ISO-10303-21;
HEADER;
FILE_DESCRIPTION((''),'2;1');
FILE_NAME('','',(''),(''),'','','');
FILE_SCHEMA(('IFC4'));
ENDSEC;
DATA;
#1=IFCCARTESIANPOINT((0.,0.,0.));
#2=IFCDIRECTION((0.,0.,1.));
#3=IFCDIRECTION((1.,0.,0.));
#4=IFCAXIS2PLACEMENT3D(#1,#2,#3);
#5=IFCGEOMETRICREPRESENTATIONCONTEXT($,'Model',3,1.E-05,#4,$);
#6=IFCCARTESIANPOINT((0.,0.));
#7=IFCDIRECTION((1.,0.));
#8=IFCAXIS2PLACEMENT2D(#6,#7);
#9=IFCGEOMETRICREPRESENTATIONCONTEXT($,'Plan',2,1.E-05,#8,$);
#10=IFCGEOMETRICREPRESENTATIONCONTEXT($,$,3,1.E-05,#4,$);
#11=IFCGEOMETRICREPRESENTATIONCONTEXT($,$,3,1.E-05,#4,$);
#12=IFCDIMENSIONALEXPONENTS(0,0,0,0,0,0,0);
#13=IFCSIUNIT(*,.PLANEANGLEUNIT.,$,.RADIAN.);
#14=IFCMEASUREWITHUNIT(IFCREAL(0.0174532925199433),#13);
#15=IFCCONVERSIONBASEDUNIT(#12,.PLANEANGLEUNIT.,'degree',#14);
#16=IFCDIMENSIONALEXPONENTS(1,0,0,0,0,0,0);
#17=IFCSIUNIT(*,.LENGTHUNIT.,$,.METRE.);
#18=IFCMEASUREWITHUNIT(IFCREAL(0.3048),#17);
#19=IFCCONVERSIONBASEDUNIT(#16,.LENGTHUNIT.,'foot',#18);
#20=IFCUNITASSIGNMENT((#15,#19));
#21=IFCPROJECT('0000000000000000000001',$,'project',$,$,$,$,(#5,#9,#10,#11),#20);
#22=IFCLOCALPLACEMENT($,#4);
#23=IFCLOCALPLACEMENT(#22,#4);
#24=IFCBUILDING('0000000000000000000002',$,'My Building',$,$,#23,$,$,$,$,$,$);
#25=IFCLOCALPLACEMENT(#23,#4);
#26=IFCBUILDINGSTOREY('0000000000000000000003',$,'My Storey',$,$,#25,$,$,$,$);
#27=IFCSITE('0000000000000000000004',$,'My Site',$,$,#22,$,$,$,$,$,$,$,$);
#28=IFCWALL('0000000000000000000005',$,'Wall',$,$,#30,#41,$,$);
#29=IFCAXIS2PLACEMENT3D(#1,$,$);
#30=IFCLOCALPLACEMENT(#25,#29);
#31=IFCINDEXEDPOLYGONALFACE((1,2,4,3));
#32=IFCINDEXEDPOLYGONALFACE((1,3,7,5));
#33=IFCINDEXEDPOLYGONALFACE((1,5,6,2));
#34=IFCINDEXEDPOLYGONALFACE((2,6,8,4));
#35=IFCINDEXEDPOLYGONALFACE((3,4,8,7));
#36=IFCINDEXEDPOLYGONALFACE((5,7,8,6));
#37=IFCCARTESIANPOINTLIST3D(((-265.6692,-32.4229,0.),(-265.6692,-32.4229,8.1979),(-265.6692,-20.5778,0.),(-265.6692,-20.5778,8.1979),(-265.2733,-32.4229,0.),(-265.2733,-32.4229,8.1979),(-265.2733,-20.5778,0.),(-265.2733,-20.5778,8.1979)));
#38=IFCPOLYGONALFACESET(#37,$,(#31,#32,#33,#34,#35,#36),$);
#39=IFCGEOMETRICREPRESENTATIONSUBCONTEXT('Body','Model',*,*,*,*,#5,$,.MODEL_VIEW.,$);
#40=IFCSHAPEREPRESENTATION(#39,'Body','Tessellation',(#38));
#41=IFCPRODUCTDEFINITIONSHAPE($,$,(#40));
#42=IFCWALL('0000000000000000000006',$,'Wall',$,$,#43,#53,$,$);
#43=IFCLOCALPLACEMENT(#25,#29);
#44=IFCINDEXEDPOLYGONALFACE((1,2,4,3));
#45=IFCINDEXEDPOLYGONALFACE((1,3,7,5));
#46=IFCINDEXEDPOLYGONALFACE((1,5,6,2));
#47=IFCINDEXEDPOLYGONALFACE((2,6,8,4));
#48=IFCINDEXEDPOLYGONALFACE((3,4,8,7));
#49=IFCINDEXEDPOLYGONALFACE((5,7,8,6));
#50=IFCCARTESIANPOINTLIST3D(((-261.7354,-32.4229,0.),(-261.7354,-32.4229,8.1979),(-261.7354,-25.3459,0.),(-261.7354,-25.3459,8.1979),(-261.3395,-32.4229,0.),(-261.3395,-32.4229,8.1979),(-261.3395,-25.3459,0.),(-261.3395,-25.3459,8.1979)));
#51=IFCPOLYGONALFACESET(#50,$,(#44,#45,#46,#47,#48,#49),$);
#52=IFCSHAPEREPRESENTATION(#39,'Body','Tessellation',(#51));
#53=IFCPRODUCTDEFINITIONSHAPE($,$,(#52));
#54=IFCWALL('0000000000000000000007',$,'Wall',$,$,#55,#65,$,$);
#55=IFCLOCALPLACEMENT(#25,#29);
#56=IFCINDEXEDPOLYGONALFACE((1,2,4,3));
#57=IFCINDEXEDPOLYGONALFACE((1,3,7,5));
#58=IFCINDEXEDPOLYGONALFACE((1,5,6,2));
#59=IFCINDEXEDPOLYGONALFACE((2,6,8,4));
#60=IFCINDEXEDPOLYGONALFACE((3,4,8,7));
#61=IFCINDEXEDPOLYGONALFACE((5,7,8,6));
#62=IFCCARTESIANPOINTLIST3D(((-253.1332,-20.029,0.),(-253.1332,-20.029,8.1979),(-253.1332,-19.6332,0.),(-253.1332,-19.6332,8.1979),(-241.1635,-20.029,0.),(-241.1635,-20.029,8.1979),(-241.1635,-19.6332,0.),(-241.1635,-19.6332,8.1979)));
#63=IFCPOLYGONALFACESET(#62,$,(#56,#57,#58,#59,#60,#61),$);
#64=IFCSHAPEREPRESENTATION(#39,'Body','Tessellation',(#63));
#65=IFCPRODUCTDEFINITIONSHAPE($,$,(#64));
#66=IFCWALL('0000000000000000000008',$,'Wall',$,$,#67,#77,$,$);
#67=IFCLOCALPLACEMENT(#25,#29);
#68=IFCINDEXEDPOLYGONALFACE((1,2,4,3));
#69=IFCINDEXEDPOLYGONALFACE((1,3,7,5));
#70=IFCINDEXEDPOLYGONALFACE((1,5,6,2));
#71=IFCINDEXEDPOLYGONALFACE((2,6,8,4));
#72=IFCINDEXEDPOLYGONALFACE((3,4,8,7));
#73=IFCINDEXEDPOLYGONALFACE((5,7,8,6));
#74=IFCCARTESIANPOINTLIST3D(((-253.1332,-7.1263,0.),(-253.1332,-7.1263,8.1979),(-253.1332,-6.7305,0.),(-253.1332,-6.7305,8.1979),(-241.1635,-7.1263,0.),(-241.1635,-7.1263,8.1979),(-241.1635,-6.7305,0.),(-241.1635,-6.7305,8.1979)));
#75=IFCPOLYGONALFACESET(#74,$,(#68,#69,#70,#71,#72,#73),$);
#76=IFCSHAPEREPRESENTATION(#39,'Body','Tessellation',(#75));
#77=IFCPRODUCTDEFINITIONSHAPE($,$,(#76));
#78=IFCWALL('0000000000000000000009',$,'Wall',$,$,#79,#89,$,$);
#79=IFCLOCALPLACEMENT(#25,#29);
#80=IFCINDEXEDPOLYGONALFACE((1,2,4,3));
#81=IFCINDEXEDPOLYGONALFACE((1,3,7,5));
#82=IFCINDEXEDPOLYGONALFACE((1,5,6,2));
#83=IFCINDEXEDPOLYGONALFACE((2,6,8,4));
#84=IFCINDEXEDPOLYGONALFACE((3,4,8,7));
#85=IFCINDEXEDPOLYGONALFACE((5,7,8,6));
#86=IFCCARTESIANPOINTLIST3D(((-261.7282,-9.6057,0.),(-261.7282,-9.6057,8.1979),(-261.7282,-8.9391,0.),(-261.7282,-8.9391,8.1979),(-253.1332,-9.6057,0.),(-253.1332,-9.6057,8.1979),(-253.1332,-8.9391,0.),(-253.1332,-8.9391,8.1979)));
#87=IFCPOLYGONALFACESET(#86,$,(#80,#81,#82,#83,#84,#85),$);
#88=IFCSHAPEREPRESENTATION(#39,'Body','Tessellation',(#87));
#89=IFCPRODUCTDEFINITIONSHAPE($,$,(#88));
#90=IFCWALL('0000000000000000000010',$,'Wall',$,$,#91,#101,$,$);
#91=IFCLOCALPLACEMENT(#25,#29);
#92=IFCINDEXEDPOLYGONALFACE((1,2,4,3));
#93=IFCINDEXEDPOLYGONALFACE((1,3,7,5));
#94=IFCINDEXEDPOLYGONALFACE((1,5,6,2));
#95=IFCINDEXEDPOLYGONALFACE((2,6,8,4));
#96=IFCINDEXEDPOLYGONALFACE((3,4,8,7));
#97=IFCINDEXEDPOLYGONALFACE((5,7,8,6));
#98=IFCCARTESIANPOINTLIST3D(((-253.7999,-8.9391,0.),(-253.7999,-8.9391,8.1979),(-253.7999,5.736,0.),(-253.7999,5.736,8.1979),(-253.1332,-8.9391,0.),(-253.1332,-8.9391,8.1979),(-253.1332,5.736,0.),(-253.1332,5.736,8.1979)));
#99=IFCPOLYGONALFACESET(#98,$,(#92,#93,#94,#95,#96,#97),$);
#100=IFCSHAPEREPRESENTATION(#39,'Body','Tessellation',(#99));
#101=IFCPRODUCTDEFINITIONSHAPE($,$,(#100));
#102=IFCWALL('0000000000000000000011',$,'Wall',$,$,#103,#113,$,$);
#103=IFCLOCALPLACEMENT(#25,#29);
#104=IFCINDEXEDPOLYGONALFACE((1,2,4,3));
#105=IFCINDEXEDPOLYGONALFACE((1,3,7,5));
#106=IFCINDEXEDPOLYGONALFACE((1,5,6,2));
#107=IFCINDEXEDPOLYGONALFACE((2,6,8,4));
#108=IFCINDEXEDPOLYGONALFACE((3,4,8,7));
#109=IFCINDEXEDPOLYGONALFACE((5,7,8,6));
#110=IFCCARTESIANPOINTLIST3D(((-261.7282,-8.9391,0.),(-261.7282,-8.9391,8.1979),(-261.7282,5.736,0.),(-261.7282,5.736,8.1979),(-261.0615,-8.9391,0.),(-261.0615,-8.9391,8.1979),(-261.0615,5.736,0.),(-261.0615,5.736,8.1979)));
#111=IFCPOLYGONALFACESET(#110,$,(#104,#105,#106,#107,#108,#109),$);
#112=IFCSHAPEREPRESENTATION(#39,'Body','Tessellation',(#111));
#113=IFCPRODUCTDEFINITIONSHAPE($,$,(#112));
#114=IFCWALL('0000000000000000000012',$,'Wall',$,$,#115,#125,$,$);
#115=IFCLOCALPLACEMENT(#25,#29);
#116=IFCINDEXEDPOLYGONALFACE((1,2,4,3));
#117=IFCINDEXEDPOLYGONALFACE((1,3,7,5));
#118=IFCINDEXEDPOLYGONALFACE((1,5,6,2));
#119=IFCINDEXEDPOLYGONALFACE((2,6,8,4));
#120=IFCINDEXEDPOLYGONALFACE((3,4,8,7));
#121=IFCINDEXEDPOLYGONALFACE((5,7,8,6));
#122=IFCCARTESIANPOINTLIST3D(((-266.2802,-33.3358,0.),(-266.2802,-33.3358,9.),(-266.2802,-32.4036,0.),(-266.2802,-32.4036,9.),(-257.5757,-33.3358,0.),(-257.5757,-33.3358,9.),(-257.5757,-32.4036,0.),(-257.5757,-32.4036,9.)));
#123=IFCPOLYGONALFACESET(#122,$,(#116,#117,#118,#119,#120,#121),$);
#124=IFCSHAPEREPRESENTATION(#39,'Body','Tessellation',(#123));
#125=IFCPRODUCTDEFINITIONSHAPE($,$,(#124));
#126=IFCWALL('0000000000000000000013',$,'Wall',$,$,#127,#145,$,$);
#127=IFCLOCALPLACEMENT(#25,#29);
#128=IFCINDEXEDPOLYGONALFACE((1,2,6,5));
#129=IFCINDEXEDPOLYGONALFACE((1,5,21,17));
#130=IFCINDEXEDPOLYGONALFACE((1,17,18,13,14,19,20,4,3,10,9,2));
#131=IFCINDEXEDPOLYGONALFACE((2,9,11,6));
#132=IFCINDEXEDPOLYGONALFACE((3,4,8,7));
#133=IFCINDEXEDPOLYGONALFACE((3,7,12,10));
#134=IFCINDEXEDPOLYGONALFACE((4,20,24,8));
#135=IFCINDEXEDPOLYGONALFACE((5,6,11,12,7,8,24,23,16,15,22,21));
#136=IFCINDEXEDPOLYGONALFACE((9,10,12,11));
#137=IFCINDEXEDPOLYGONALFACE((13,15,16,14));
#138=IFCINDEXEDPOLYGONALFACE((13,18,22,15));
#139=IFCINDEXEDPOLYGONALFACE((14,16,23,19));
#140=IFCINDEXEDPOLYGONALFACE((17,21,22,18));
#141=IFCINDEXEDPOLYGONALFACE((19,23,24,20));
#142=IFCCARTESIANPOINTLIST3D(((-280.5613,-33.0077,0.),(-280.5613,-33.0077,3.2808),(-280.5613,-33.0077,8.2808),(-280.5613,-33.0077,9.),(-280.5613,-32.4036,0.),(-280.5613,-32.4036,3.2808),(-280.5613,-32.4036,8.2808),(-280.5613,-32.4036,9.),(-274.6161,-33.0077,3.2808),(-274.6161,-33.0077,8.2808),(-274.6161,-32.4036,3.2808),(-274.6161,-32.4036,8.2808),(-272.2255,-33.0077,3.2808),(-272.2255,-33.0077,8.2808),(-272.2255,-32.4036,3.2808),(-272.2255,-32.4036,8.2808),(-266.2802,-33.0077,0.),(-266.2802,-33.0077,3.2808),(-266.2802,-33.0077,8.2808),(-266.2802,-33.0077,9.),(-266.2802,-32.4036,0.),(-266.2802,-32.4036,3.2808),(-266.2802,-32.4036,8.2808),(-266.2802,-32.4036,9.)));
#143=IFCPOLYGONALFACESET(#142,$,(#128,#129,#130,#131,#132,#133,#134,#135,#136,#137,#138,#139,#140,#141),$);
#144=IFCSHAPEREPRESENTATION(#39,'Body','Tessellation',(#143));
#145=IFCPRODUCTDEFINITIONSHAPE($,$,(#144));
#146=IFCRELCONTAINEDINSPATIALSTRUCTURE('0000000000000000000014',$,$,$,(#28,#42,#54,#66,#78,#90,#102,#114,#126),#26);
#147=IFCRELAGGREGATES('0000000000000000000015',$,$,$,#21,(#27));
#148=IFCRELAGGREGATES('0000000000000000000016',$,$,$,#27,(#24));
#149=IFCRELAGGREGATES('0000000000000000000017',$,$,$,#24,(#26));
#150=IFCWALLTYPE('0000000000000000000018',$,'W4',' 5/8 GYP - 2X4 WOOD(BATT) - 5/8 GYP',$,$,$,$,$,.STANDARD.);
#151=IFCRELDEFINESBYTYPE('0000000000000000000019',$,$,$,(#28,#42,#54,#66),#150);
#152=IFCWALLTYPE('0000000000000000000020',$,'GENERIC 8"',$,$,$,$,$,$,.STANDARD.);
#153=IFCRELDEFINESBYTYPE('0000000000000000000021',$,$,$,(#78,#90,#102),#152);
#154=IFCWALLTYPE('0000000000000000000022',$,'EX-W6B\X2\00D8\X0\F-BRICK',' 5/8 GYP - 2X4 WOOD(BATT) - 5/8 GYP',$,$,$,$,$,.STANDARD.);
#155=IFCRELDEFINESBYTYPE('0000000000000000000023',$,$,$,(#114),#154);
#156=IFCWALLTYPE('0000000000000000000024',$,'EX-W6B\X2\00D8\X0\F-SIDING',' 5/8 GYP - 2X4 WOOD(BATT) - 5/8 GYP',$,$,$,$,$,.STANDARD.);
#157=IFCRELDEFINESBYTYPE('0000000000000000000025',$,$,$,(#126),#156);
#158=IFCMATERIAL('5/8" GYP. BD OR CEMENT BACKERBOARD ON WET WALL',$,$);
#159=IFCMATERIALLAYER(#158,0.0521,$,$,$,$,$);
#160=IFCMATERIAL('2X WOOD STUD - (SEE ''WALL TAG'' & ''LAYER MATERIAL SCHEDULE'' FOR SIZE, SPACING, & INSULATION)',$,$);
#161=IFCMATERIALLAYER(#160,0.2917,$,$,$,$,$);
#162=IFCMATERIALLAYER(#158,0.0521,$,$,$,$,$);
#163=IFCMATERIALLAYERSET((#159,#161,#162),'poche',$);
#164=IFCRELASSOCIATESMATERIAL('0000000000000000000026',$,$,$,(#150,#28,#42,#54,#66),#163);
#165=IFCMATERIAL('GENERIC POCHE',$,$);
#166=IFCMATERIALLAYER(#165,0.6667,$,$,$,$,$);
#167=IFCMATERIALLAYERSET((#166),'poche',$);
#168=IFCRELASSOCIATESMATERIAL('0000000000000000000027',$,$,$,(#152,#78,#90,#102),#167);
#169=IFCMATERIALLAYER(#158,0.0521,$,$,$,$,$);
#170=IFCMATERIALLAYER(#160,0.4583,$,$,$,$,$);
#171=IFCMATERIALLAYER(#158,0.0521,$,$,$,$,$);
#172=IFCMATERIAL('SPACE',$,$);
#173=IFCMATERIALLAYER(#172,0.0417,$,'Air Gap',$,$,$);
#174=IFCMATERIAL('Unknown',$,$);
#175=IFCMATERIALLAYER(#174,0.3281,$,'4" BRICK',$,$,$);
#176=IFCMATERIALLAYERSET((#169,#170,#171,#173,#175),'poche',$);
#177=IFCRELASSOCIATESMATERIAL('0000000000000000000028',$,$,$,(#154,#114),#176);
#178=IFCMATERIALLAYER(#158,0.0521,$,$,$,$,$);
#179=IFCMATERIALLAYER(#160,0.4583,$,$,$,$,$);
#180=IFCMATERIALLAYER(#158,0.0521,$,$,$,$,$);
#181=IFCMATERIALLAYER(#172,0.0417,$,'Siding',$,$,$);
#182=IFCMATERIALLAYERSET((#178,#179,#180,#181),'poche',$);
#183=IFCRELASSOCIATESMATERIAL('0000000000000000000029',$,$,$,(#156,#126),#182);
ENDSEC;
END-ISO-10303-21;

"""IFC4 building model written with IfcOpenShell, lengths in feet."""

from ifc_helpers import new_model, entity, si_unit, converted_unit, frame, origin_with_axes, origin_2d_with_axis, place, context, subcontext, project, spatial, line, indexed_curve, outline, extrude, source, transform, mapped, material, layer, layer_set, layer_usage, type_object, element, save


model = new_model("IFC4")

# Units and contexts
model_context = context("Model", 3, precision=1e-05, world=origin_with_axes())
plan_context = context("Plan", 2, precision=1e-05, world=origin_2d_with_axis())
context_of_model_1 = context(None, 3, precision=1e-05, world=origin_with_axes())
context_of_model_2 = context(None, 3, precision=1e-05, world=origin_with_axes())
body_context_1 = subcontext(model_context, "Body", "Model", "MODEL_VIEW")
ifc_project = project(units=[converted_unit("PLANEANGLEUNIT", "degree", entity("IfcReal", 0.0174532925199433), si_unit("PLANEANGLEUNIT", "RADIAN"), dimensions=[0, 0, 0, 0, 0, 0, 0]), converted_unit("LENGTHUNIT", "foot", entity("IfcReal", 0.3048), si_unit("LENGTHUNIT", "METRE"), dimensions=[1, 0, 0, 0, 0, 0, 0])], contexts=[model_context, plan_context, context_of_model_1, context_of_model_2])

# Site, building, storey
site_placement = place(None, origin_with_axes())
site = spatial("IfcSite", under=ifc_project, at=site_placement, Name="My Site")
building_placement = place(site_placement, origin_with_axes())
building = spatial("IfcBuilding", under=site, at=building_placement, Name="My Building")
storey_placement = place(building_placement, origin_with_axes())
storey = spatial("IfcBuildingStorey", under=building, at=storey_placement, Name="My Storey")

# Walls
ifc_material_1 = material(Name="5/8\" GYP. BD OR CEMENT BACKERBOARD ON WET WALL")
ifc_layer_1 = layer(ifc_material_1, 0.0521)
ifc_material_2 = material(Name="2X WOOD STUD - (SEE 'WALL TAG' & 'LAYER MATERIAL SCHEDULE' FOR SIZE, SPACING, & INSULATION)")
ifc_layer_2 = layer(ifc_material_2, 0.2917)
ifc_layer_3 = layer(ifc_material_1, 0.0521)
ifc_layer_set_1 = layer_set([ifc_layer_1, ifc_layer_2, ifc_layer_3], Name="poche")
ifc_layer_usage_1 = layer_usage(ifc_layer_set_1, "AXIS2", "POSITIVE", 0.0)
wall_type_1 = type_object("IfcWallType", Name="W4", Description=" 5/8 GYP - 2X4 WOOD(BATT) - 5/8 GYP", PredefinedType="STANDARD", material=ifc_layer_set_1)
wall_1_placement = place(storey_placement, frame((-265.2733, -32.4229, 0.0), z_axis=(0.0, 0.0, 1.0), x_axis=(0.0, 1.0, 0.0)))
element("IfcWall", 1, at=wall_1_placement, inside=storey, type_object=wall_type_1, material=ifc_layer_usage_1, Name="Wall", context=body_context_1, shape_type="SweptSolid", body=[
    extrude(outline(indexed_curve([(0.0, 0.0), (0.0, 0.3958), (11.8451, 0.3958), (11.8451, 0.0), (0.0, 0.0)], self_intersect=False)), origin_with_axes(), (0.0, 0.0, 1.0), 8.1979),
])
ifc_layer_usage_2 = layer_usage(ifc_layer_set_1, "AXIS2", "POSITIVE", 0.0)
wall_2_placement = place(storey_placement, frame((-261.3395, -32.4229, 0.0), z_axis=(0.0, 0.0, 1.0), x_axis=(0.0, 1.0, 0.0)))
element("IfcWall", 2, at=wall_2_placement, inside=storey, type_object=wall_type_1, material=ifc_layer_usage_2, Name="Wall", context=body_context_1, shape_type="SweptSolid", body=[
    extrude(outline(indexed_curve([(0.0, 0.0), (0.0, 0.3958), (7.077, 0.3958), (7.077, 0.0), (0.0, 0.0)], self_intersect=False)), origin_with_axes(), (0.0, 0.0, 1.0), 8.1979),
])

# Walls
ifc_layer_usage_3 = layer_usage(ifc_layer_set_1, "AXIS2", "POSITIVE", 0.0)
wall_3_placement = place(storey_placement, frame((-253.1332, -20.029, 0.0), z_axis=(0.0, 0.0, 1.0), x_axis=(1.0, 0.0, 0.0)))
element("IfcWall", 3, at=wall_3_placement, inside=storey, type_object=wall_type_1, material=ifc_layer_usage_3, Name="Wall", context=body_context_1, shape_type="SweptSolid", body=[
    extrude(outline(indexed_curve([(0.0, 0.0), (0.0, 0.3958), (11.9697, 0.3958), (11.9697, 0.0), (0.0, 0.0)], self_intersect=False)), origin_with_axes(), (0.0, 0.0, 1.0), 8.1979),
])
ifc_layer_usage_4 = layer_usage(ifc_layer_set_1, "AXIS2", "POSITIVE", 0.0)
wall_4_placement = place(storey_placement, frame((-253.1332, -7.1263, 0.0), z_axis=(0.0, 0.0, 1.0), x_axis=(1.0, 0.0, 0.0)))
element("IfcWall", 4, at=wall_4_placement, inside=storey, type_object=wall_type_1, material=ifc_layer_usage_4, Name="Wall", context=body_context_1, shape_type="SweptSolid", body=[
    extrude(outline(indexed_curve([(0.0, 0.0), (0.0, 0.3958), (11.9697, 0.3958), (11.9697, 0.0), (0.0, 0.0)], self_intersect=False)), origin_with_axes(), (0.0, 0.0, 1.0), 8.1979),
])
ifc_material_3 = material(Name="GENERIC POCHE")
ifc_layer_4 = layer(ifc_material_3, 0.6667)
ifc_layer_set_2 = layer_set([ifc_layer_4], Name="poche")
ifc_layer_usage_5 = layer_usage(ifc_layer_set_2, "AXIS2", "POSITIVE", 0.0)
wall_type_2 = type_object("IfcWallType", Name="GENERIC 8\"", PredefinedType="STANDARD", material=ifc_layer_set_2)
wall_5_placement = place(storey_placement, frame((-261.7282, -9.6057, 0.0), z_axis=(0.0, 0.0, 1.0), x_axis=(1.0, 0.0, 0.0)))
element("IfcWall", 5, at=wall_5_placement, inside=storey, type_object=wall_type_2, material=ifc_layer_usage_5, Name="Wall", context=body_context_1, shape_type="SweptSolid", body=[
    extrude(outline(indexed_curve([(0.0, 0.0), (0.0, 0.6667), (8.595, 0.6667), (8.595, 0.0), (0.0, 0.0)], self_intersect=False)), origin_with_axes(), (0.0, 0.0, 1.0), 8.1979),
])
ifc_layer_usage_6 = layer_usage(ifc_layer_set_2, "AXIS2", "POSITIVE", 0.0)
wall_6_placement = place(storey_placement, frame((-253.7999, 5.736, 0.0), z_axis=(0.0, 0.0, 1.0), x_axis=(0.0, -1.0, 0.0)))
element("IfcWall", 6, at=wall_6_placement, inside=storey, type_object=wall_type_2, material=ifc_layer_usage_6, Name="Wall", context=body_context_1, shape_type="SweptSolid", body=[
    extrude(outline(indexed_curve([(0.0, 0.0), (0.0, 0.6667), (14.675, 0.6667), (14.675, 0.0), (0.0, 0.0)], self_intersect=False)), origin_with_axes(), (0.0, 0.0, 1.0), 8.1979),
])
ifc_layer_usage_7 = layer_usage(ifc_layer_set_2, "AXIS2", "POSITIVE", 0.0)
wall_7_placement = place(storey_placement, frame((-261.0615, -8.9391, 0.0), z_axis=(0.0, 0.0, 1.0), x_axis=(0.0, 1.0, 0.0)))
element("IfcWall", 7, at=wall_7_placement, inside=storey, type_object=wall_type_2, material=ifc_layer_usage_7, Name="Wall", context=body_context_1, shape_type="SweptSolid", body=[
    extrude(outline(indexed_curve([(0.0, 0.0), (0.0, 0.6667), (14.675, 0.6667), (14.675, 0.0), (0.0, 0.0)], self_intersect=False)), origin_with_axes(), (0.0, 0.0, 1.0), 8.1979),
])

# Wall
ifc_layer_5 = layer(ifc_material_1, 0.0521)
ifc_layer_6 = layer(ifc_material_2, 0.4583)
ifc_layer_7 = layer(ifc_material_1, 0.0521)
ifc_material_4 = material(Name="SPACE")
ifc_layer_8 = layer(ifc_material_4, 0.0417, Name="Air Gap")
ifc_material_5 = material(Name="Unknown")
ifc_layer_9 = layer(ifc_material_5, 0.3281, Name="4\" BRICK")
ifc_layer_set_3 = layer_set([ifc_layer_5, ifc_layer_6, ifc_layer_7, ifc_layer_8, ifc_layer_9], Name="poche")
ifc_layer_usage_8 = layer_usage(ifc_layer_set_3, "AXIS2", "POSITIVE", 0.0)
wall_type_3 = type_object("IfcWallType", Name="EX-W6BØF-BRICK", Description=" 5/8 GYP - 2X4 WOOD(BATT) - 5/8 GYP", PredefinedType="STANDARD", material=ifc_layer_set_3)
wall_8_placement = place(storey_placement, frame((-257.5757, -32.4036, 0.0), z_axis=(0.0, 0.0, 1.0), x_axis=(-1.0, 0.0, 0.0)))
element("IfcWall", 8, at=wall_8_placement, inside=storey, type_object=wall_type_3, material=ifc_layer_usage_8, Name="Wall", context=body_context_1, shape_type="SweptSolid", body=[
    extrude(outline(indexed_curve([(0.0, 0.0), (0.0, 0.9323), (8.7045, 0.9323), (8.7045, 0.0), (0.0, 0.0)], self_intersect=False)), origin_with_axes(), (0.0, 0.0, 1.0), 9.0),
])

# Wall, openings
ifc_layer_10 = layer(ifc_material_1, 0.0521)
ifc_layer_11 = layer(ifc_material_2, 0.4583)
ifc_layer_12 = layer(ifc_material_1, 0.0521)
ifc_layer_13 = layer(ifc_material_4, 0.0417, Name="Siding")
ifc_layer_set_4 = layer_set([ifc_layer_10, ifc_layer_11, ifc_layer_12, ifc_layer_13], Name="poche")
ifc_layer_usage_9 = layer_usage(ifc_layer_set_4, "AXIS2", "POSITIVE", 0.0)
wall_type_4 = type_object("IfcWallType", Name="EX-W6BØF-SIDING", Description=" 5/8 GYP - 2X4 WOOD(BATT) - 5/8 GYP", PredefinedType="STANDARD", material=ifc_layer_set_4)
wall_9_placement = place(storey_placement, frame((-266.2802, -32.4036, 0.0), z_axis=(0.0, 0.0, 1.0), x_axis=(-1.0, 0.0, 0.0)))
wall_9 = element("IfcWall", 9, at=wall_9_placement, inside=storey, type_object=wall_type_4, material=ifc_layer_usage_9, Name="Wall", context=body_context_1, shape_type="SweptSolid", body=[
    extrude(outline(indexed_curve([(0.0, 0.0), (0.0, 0.6042), (14.2811, 0.6042), (14.2811, 0.0), (0.0, 0.0)], self_intersect=False)), origin_with_axes(), (0.0, 0.0, 1.0), 9.0),
])
shared_shape_1 = source(origin_with_axes(), body_context_1, "Body", "SweptSolid", [
    extrude(outline(indexed_curve([(0.0, 0.0), (5.9453, 0.0), (5.9453, 5.0), (0.0, 5.0)], segments=[line(1, 2, 3, 4, 1)])), frame((0.0, -0.3281, 0.0), z_axis=(0.0, -1.0, 0.0), x_axis=(1.0, 0.0, 0.0)), (0.0, 0.0, -1.0), 1.2603),
])
opening_1_placement = place(wall_9_placement, frame((0.0, 0.0, 3.2808), z_axis=(0.0, 0.0, 1.0), x_axis=(1.0, 0.0, 0.0)))
element("IfcOpeningElement", 10, at=opening_1_placement, cuts=wall_9, PredefinedType="OPENING", context=body_context_1, shape_type="MappedRepresentation", body=[
    mapped(shared_shape_1, transform((0.0, 0.0, 0.0), x_axis=(1.0, 0.0, 0.0), y_axis=(0.0, 1.0, 0.0), z_axis=(0.0, 0.0, 1.0), scale=1.0)),
])
opening_2_placement = place(wall_9_placement, frame((8.3358, 0.0, 3.2808), z_axis=(0.0, 0.0, 1.0), x_axis=(1.0, 0.0, 0.0)))
element("IfcOpeningElement", 11, at=opening_2_placement, cuts=wall_9, PredefinedType="OPENING", context=body_context_1, shape_type="MappedRepresentation", body=[
    mapped(shared_shape_1, transform((0.0, 0.0, 0.0), x_axis=(1.0, 0.0, 0.0), y_axis=(0.0, 1.0, 0.0), z_axis=(0.0, 0.0, 1.0), scale=1.0)),
])

save(model, "model.ifc")
